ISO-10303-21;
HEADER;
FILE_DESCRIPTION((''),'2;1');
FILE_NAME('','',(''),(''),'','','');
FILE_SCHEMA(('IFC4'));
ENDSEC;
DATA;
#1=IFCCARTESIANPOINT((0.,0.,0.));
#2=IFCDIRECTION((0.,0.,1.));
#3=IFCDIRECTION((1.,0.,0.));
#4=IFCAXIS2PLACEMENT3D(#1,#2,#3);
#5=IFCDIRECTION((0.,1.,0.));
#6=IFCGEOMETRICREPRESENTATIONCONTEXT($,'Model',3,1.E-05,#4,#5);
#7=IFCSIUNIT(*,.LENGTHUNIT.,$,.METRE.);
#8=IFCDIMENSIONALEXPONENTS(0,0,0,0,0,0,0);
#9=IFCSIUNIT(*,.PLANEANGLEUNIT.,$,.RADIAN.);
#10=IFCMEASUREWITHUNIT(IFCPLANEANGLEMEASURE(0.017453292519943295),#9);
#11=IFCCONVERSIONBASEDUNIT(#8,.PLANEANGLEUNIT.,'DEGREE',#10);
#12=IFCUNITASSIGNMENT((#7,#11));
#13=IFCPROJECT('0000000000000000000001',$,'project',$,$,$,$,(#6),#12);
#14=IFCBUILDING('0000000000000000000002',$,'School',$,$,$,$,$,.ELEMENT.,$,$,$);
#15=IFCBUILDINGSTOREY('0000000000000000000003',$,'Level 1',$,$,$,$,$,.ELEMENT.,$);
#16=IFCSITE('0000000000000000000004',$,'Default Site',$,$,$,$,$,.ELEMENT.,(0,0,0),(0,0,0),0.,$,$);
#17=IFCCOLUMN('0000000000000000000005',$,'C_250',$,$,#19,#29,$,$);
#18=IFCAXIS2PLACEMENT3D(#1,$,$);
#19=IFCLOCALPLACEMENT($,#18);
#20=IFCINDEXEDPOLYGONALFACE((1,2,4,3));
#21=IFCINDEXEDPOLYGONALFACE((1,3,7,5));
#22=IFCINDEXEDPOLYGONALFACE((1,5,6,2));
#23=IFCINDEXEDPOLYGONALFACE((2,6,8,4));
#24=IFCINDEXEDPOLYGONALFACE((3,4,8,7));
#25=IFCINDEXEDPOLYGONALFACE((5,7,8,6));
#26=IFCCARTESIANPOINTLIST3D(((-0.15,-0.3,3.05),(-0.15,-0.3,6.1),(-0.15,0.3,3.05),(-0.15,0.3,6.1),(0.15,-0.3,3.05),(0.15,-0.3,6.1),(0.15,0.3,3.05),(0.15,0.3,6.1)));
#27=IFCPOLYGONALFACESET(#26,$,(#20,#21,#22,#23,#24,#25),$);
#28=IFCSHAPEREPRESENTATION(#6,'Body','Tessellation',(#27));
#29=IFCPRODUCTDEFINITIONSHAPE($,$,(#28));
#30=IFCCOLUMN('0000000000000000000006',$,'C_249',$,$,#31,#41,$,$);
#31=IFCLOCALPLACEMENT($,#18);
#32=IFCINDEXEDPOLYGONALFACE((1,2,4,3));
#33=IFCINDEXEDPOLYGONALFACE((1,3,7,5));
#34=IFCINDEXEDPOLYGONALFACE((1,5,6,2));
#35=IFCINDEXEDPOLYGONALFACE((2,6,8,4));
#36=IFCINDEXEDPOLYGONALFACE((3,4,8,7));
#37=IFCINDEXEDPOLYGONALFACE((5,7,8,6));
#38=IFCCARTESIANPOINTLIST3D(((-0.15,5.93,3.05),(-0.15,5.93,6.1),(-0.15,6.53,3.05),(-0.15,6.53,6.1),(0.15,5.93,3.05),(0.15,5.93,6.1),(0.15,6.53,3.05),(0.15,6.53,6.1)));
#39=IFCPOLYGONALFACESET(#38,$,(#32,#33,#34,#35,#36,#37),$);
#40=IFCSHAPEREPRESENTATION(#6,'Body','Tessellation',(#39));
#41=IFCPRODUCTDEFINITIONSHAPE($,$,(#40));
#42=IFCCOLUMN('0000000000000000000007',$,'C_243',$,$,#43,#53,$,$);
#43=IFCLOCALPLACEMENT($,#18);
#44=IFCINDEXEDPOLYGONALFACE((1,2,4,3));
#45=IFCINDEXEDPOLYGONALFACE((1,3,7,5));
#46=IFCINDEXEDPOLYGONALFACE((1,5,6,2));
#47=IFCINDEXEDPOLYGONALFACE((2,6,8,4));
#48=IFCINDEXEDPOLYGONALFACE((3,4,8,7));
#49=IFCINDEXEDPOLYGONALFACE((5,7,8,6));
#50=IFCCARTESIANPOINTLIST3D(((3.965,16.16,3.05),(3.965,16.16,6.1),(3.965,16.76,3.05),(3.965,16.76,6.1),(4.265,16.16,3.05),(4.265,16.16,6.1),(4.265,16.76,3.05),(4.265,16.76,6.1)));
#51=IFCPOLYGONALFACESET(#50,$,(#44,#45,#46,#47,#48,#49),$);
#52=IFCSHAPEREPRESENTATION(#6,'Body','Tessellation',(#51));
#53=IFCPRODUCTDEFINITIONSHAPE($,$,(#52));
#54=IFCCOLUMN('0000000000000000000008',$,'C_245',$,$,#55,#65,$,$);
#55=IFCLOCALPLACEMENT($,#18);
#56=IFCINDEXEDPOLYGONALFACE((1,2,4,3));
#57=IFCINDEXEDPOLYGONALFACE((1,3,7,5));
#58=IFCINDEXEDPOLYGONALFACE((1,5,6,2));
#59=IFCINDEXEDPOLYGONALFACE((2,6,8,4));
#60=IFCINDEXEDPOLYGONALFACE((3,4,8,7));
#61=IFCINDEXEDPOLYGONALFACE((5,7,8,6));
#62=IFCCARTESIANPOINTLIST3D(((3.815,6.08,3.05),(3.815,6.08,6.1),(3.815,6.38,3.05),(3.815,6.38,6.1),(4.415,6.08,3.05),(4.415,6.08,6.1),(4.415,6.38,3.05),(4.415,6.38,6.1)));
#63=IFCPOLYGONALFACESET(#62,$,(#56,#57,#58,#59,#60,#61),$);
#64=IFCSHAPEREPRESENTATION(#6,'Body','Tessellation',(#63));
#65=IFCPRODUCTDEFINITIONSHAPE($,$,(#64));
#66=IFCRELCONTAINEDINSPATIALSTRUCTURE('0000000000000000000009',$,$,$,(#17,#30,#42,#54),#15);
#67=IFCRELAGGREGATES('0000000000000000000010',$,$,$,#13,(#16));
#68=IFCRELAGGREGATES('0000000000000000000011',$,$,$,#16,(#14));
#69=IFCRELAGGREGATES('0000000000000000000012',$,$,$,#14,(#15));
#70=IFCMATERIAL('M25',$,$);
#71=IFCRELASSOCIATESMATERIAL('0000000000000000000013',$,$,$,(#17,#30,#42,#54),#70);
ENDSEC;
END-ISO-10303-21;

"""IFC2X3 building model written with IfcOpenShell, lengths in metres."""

from ifc_helpers import new_model, entity, si_unit, converted_unit, direction, frame, frame_2d, origin_with_axes, place, context, project, spatial, rectangle, extrude, material, element, save


model = new_model("IFC2X3")

# Units and contexts
model_context = context("Model", 3, precision=1e-05, world=origin_with_axes(), true_north=direction((0.0, 1.0, 0.0)))
ifc_project = project(units=[si_unit("LENGTHUNIT", "METRE"), converted_unit("PLANEANGLEUNIT", "DEGREE", entity("IfcPlaneAngleMeasure", 0.017453292519943295), si_unit("PLANEANGLEUNIT", "RADIAN"), dimensions=[0, 0, 0, 0, 0, 0, 0])], contexts=[model_context])

# Site, building, storey
site = spatial("IfcSite", under=ifc_project, Name="Default Site", CompositionType="ELEMENT", RefLatitude=(0, 0, 0), RefLongitude=(0, 0, 0), RefElevation=0.0)
building = spatial("IfcBuilding", under=site, Name="School", CompositionType="ELEMENT")
storey = spatial("IfcBuildingStorey", under=building, Name="Level 1", CompositionType="ELEMENT")

# Columns
ifc_material = material(Name="M25")
placement = place(None, origin_with_axes())
element("IfcColumn", 1, at=placement, inside=storey, material=ifc_material, Name="C_250", context=model_context, shape_type="SweptSolid", body=[
    extrude(rectangle(XDim=0.3, YDim=0.6, at=frame_2d((0.0, 0.0), x_axis=(1.0, 0.0, 0.0))), frame((0.0, 0.0, 3.05), z_axis=(0.0, 0.0, 1.0), x_axis=(1.0, 0.0, 0.0)), (0.0, 0.0, 1.0), 3.05),
])
element("IfcColumn", 2, at=placement, inside=storey, material=ifc_material, Name="C_249", context=model_context, shape_type="SweptSolid", body=[
    extrude(rectangle(XDim=0.3, YDim=0.6, at=frame_2d((0.0, 0.0), x_axis=(1.0, 0.0, 0.0))), frame((0.0, 6.23, 3.05), z_axis=(0.0, 0.0, 1.0), x_axis=(1.0, 0.0, 0.0)), (0.0, 0.0, 1.0), 3.05),
])
element("IfcColumn", 3, at=placement, inside=storey, material=ifc_material, Name="C_243", context=model_context, shape_type="SweptSolid", body=[
    extrude(rectangle(XDim=0.3, YDim=0.6, at=frame_2d((0.0, 0.0), x_axis=(1.0, 0.0, 0.0))), frame((4.115, 16.46, 3.05), z_axis=(0.0, 0.0, 1.0), x_axis=(1.0, 0.0, 0.0)), (0.0, 0.0, 1.0), 3.05),
])
element("IfcColumn", 4, at=placement, inside=storey, material=ifc_material, Name="C_245", context=model_context, shape_type="SweptSolid", body=[
    extrude(rectangle(XDim=0.6, YDim=0.3, at=frame_2d((0.0, 0.0), x_axis=(1.0, 0.0, 0.0))), frame((4.115, 6.23, 3.05), z_axis=(0.0, 0.0, 1.0), x_axis=(1.0, 0.0, 0.0)), (0.0, 0.0, 1.0), 3.05),
])

save(model, "model.ifc")
